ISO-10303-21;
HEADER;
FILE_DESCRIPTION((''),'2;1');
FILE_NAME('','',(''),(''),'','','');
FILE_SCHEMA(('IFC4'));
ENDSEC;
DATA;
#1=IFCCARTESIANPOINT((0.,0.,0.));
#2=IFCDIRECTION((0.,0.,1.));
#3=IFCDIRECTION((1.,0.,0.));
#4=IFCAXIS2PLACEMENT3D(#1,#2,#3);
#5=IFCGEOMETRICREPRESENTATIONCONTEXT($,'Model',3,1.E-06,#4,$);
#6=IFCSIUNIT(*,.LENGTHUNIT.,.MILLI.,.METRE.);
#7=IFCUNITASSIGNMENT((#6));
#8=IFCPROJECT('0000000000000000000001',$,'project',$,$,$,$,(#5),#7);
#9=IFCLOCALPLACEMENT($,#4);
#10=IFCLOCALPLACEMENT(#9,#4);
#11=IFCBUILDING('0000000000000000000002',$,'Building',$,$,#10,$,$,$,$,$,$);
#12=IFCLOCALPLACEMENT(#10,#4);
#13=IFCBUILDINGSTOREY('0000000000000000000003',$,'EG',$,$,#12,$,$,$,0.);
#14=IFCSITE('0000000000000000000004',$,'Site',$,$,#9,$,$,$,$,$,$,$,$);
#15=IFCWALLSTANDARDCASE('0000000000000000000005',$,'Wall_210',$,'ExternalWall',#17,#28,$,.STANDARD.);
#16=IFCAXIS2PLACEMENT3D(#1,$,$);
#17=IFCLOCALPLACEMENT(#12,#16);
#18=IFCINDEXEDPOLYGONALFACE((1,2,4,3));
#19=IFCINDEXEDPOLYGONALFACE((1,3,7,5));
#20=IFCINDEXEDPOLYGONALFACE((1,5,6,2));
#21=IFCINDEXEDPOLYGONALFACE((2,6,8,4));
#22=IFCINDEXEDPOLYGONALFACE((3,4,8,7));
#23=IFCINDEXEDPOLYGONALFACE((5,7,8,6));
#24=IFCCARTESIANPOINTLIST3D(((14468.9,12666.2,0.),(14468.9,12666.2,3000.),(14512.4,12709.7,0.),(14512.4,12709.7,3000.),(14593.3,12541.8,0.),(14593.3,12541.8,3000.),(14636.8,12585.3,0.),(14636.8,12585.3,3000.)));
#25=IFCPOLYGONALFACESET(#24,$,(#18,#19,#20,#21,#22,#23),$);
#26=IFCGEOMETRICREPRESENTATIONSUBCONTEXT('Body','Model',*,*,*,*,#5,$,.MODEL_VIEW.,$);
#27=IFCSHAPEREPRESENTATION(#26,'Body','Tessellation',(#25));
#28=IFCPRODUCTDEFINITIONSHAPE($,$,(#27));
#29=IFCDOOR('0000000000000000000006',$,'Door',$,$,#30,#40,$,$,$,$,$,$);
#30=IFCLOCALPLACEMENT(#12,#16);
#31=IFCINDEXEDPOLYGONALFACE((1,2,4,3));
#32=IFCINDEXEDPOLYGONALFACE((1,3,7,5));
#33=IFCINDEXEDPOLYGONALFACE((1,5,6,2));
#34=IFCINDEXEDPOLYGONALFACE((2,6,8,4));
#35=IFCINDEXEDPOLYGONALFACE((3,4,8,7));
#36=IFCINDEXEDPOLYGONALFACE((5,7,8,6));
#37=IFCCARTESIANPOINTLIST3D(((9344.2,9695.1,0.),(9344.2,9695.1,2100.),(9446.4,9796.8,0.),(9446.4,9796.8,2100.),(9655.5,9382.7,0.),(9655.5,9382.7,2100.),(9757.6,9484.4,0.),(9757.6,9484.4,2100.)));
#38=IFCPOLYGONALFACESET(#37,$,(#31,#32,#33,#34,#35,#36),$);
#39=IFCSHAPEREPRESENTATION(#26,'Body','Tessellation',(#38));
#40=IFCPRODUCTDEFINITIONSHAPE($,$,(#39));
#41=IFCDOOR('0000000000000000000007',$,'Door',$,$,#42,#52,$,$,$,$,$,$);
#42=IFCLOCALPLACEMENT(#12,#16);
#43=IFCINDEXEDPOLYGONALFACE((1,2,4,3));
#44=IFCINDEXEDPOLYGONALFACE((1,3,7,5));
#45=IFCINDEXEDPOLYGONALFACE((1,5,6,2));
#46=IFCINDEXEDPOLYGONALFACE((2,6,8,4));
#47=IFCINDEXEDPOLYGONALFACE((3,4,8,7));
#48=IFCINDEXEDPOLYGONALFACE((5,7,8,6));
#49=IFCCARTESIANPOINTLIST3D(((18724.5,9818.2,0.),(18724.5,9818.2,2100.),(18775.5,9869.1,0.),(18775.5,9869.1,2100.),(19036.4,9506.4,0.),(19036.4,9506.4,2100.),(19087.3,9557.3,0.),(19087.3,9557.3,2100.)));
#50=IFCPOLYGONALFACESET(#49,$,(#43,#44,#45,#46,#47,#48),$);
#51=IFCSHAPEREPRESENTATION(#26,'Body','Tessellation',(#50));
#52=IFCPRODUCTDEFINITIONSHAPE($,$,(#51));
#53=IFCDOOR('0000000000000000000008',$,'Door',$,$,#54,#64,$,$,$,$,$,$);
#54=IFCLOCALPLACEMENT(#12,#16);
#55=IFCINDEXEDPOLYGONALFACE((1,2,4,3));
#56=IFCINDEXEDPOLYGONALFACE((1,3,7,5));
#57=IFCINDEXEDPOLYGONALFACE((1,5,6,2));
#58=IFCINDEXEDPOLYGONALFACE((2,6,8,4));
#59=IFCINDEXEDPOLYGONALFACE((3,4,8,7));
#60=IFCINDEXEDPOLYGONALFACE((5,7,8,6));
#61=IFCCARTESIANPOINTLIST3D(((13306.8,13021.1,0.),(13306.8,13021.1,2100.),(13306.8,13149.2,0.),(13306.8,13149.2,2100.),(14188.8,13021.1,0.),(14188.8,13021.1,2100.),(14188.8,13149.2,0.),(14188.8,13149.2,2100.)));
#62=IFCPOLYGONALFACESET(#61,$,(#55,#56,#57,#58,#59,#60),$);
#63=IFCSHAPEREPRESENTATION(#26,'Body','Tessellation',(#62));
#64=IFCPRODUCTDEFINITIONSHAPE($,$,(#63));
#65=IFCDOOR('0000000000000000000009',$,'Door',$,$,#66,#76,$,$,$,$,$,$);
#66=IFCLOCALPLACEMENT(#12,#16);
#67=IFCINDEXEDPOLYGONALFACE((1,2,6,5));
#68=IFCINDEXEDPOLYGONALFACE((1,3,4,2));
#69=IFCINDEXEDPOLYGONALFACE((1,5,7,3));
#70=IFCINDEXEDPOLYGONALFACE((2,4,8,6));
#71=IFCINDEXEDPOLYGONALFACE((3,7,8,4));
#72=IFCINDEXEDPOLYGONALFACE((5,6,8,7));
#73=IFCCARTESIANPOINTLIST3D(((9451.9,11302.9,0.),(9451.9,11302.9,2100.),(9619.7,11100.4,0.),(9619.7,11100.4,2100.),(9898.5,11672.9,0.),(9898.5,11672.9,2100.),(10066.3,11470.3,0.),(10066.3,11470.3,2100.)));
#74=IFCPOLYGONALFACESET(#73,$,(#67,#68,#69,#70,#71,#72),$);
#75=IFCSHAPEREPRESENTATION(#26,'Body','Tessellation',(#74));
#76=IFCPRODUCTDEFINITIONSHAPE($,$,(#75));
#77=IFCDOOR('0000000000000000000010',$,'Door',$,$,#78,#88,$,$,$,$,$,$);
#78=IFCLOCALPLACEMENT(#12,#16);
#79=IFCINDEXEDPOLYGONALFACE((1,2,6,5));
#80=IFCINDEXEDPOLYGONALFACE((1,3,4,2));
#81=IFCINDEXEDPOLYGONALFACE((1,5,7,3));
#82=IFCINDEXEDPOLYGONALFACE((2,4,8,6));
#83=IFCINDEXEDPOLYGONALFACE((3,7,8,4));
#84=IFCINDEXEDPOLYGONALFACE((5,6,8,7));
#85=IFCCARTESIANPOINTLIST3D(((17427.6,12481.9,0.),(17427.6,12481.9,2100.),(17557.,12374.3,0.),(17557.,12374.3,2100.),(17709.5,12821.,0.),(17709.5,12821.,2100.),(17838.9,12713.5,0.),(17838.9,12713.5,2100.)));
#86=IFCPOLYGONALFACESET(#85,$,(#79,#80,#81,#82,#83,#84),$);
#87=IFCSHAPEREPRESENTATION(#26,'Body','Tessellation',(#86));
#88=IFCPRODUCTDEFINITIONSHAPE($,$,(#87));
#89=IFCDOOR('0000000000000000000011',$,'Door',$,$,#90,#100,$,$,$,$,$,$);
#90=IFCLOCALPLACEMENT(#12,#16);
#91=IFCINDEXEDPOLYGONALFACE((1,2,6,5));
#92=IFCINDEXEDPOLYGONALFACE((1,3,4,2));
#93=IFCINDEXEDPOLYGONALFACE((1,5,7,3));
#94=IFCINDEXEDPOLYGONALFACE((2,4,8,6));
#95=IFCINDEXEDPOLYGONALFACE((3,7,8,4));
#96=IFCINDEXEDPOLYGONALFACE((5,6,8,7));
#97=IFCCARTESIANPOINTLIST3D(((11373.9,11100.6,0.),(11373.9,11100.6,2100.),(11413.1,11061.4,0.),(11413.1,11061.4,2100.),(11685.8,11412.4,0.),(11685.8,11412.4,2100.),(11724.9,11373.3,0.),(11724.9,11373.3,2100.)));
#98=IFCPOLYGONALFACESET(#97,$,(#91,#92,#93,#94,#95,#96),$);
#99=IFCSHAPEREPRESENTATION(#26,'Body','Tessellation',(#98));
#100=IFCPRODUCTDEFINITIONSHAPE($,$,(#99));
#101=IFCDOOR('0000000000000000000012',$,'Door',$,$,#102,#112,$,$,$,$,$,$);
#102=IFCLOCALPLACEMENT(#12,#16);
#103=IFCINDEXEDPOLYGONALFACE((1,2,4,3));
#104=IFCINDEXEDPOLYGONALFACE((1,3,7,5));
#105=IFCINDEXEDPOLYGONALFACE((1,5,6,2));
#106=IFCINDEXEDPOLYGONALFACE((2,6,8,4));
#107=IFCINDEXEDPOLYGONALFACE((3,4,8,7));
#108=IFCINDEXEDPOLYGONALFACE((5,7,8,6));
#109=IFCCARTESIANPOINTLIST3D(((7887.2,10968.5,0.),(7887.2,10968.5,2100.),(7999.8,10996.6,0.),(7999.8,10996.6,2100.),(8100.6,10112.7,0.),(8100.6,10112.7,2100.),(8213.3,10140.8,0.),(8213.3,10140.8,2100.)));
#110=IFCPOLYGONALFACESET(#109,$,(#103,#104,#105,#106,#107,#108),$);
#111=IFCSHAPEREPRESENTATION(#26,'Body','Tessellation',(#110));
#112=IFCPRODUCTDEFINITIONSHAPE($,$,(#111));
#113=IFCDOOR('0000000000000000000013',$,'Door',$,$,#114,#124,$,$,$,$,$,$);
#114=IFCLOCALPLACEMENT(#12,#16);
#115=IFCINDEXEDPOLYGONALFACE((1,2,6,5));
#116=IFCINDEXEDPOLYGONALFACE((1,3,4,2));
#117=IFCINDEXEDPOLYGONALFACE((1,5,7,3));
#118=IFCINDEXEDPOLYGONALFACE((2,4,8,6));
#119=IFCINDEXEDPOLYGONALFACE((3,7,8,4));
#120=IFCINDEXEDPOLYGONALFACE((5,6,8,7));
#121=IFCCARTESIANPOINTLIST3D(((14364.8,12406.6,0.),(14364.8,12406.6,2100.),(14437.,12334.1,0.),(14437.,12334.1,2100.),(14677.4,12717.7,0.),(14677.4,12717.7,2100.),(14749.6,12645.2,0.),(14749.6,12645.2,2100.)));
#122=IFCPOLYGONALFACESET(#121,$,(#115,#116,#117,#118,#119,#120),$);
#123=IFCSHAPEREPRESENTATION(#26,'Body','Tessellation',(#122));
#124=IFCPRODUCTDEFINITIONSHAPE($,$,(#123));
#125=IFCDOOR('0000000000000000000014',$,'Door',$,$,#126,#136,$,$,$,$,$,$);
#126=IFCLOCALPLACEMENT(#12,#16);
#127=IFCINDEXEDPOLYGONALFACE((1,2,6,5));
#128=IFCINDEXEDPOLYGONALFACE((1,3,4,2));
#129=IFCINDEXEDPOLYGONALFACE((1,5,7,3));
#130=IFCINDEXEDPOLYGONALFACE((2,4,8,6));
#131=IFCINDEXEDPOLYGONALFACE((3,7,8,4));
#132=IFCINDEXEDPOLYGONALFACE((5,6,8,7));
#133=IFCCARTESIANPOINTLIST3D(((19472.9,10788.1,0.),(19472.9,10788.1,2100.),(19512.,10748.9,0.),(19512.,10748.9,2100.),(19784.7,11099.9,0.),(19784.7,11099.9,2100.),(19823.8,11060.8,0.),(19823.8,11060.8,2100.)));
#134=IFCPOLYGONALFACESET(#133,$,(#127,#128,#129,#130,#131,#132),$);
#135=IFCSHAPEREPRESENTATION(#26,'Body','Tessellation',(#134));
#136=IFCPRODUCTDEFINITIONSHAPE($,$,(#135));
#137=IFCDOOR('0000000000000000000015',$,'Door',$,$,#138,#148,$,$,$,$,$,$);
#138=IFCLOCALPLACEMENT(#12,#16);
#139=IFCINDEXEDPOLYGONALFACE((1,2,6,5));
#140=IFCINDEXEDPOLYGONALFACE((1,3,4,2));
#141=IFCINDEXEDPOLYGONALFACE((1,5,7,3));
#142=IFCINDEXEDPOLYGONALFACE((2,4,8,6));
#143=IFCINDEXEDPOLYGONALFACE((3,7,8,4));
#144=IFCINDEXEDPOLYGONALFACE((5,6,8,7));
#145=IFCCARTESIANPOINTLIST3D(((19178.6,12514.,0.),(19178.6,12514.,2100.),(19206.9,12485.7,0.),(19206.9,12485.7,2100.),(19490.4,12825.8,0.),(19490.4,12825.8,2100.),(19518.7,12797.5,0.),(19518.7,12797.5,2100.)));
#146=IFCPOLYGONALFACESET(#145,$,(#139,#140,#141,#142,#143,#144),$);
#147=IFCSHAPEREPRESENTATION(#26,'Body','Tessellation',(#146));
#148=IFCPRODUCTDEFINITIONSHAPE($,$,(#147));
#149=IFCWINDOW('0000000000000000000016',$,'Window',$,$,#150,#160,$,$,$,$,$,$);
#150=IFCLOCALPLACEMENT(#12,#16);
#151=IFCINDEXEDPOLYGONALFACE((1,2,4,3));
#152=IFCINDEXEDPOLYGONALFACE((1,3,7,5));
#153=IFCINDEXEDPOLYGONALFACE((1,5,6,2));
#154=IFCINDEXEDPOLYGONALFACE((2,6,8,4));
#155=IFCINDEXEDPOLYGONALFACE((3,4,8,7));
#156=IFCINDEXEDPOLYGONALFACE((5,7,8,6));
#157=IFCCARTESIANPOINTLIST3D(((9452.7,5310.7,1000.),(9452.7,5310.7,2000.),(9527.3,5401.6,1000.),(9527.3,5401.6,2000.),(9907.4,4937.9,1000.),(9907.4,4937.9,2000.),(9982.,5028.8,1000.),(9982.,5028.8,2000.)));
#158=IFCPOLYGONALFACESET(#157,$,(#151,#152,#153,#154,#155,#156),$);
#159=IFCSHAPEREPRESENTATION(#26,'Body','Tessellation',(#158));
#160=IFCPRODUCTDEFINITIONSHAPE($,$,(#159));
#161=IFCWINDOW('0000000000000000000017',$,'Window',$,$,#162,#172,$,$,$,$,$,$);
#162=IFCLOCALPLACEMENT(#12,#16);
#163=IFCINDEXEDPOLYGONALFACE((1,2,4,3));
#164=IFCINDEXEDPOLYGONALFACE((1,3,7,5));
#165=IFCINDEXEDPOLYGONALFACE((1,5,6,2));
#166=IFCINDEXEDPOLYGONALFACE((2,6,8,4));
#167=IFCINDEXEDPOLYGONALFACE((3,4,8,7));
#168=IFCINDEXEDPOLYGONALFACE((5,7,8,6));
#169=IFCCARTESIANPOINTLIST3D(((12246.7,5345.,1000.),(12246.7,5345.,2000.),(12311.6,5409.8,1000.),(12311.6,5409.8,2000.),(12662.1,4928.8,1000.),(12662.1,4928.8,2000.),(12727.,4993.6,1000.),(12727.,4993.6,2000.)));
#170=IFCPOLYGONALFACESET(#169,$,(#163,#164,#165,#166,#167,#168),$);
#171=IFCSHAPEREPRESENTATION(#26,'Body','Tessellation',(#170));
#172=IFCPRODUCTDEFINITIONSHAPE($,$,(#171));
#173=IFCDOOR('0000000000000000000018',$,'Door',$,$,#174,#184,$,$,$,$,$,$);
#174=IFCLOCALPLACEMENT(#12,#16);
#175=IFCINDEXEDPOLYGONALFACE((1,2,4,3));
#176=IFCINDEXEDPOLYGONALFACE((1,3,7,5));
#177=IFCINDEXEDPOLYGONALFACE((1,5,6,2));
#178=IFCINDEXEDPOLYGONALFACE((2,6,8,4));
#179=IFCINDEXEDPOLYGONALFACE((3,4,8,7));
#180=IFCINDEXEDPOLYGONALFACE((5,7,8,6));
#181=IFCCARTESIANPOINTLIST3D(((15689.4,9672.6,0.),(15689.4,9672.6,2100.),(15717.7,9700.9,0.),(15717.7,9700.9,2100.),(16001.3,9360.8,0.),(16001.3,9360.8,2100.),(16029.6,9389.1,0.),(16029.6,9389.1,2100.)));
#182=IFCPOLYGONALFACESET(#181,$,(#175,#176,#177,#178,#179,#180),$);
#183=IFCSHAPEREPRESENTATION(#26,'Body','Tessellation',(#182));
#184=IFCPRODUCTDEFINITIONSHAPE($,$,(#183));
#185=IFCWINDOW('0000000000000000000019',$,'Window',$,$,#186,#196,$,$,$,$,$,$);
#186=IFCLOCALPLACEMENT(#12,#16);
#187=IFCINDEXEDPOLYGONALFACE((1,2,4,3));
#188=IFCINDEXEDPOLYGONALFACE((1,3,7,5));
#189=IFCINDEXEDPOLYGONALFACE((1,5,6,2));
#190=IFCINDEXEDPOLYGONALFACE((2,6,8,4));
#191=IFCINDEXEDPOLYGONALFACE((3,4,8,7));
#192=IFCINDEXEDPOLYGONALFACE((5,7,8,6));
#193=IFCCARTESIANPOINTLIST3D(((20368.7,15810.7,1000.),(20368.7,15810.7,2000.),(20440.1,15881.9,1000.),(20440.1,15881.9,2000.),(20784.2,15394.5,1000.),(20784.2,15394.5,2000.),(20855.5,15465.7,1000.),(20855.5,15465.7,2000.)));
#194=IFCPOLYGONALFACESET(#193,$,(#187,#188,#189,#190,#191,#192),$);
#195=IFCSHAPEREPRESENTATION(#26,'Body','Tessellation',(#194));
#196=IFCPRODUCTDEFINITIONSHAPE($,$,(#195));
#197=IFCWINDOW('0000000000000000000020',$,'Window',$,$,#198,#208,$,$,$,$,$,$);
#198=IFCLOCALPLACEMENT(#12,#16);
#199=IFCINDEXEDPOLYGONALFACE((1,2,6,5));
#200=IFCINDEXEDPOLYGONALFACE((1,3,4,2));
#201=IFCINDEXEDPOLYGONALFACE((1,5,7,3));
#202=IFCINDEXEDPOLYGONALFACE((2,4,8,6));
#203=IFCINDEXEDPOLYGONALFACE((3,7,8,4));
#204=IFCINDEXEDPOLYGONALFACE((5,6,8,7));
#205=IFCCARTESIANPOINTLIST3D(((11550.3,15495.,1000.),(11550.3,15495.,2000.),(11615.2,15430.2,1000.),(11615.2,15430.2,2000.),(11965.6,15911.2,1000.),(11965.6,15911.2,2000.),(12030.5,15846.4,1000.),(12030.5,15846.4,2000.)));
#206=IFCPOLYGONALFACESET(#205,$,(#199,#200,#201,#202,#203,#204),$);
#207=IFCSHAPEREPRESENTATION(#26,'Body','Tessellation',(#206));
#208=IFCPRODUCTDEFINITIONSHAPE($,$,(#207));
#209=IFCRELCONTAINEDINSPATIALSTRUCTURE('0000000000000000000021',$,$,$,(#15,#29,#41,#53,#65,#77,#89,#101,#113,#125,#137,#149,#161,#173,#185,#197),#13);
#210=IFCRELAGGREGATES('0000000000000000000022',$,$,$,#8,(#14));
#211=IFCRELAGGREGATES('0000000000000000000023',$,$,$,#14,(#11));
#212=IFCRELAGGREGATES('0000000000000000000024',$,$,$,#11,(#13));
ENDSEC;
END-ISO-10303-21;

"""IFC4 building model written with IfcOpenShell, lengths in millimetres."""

from ifc_helpers import new_model, si_unit, frame, origin_with_axes, place, context, subcontext, project, spatial, rectangle, extrude, element, save


model = new_model("IFC4")

# Units and contexts
model_context = context("Model", 3, precision=1e-06, world=origin_with_axes())
body_context = subcontext(model_context, "Body", "Model", "MODEL_VIEW")
ifc_project = project(units=[si_unit("LENGTHUNIT", "METRE", prefix="MILLI")], contexts=[model_context])

# Site, building, storey
site_placement = place(None, origin_with_axes())
site = spatial("IfcSite", under=ifc_project, at=site_placement, Name="Site")
building_placement = place(site_placement, origin_with_axes())
building = spatial("IfcBuilding", under=site, at=building_placement, Name="Building")
storey_placement = place(building_placement, origin_with_axes())
storey = spatial("IfcBuildingStorey", under=building, at=storey_placement, Name="EG", Elevation=0.0)

# Wall
wall_placement = place(storey_placement, origin_with_axes())
element("IfcWallStandardCase", 1, at=wall_placement, inside=storey, Name="Wall_210", ObjectType="ExternalWall", PredefinedType="STANDARD", context=body_context, shape_type="SweptSolid", body=[
    extrude(rectangle(XDim=61.5, YDim=175.9), frame((14552.8, 12625.8, 0.0), z_axis=(0.0, 0.0, 1.0), x_axis=(-0.707107, -0.707107, 0.0)), (0.0, 0.0, 1.0), 3000.0),
])

# Doors
door_1_placement = place(storey_placement, origin_with_axes())
element("IfcDoor", 2, at=door_1_placement, inside=storey, Name="Door", context=body_context, shape_type="SweptSolid", body=[
    extrude(rectangle(XDim=441.0, YDim=144.2), frame((9550.9, 9589.8, 0.0), z_axis=(0.0, 0.0, 1.0), x_axis=(0.705748, -0.708463, 0.0)), (0.0, 0.0, 1.0), 2100.0),
])
door_2_placement = place(storey_placement, origin_with_axes())
element("IfcDoor", 3, at=door_2_placement, inside=storey, Name="Door", context=body_context, shape_type="SweptSolid", body=[
    extrude(rectangle(XDim=441.0, YDim=72.0), frame((18905.9, 9687.8, 0.0), z_axis=(0.0, 0.0, 1.0), x_axis=(0.707107, -0.707107, 0.0)), (0.0, 0.0, 1.0), 2100.0),
])
door_3_placement = place(storey_placement, origin_with_axes())
element("IfcDoor", 4, at=door_3_placement, inside=storey, Name="Door", context=body_context, shape_type="SweptSolid", body=[
    extrude(rectangle(XDim=882.0, YDim=128.1), frame((13747.8, 13085.1, 0.0), z_axis=(0.0, 0.0, 1.0), x_axis=(-1.0, 0.0, 0.0)), (0.0, 0.0, 1.0), 2100.0),
])
door_4_placement = place(storey_placement, origin_with_axes())
element("IfcDoor", 5, at=door_4_placement, inside=storey, Name="Door", context=body_context, shape_type="SweptSolid", body=[
    extrude(rectangle(XDim=580.0, YDim=263.0), frame((9759.1, 11386.6, 0.0), z_axis=(0.0, 0.0, 1.0), x_axis=(-0.770122, -0.637896, 0.0)), (0.0, 0.0, 1.0), 2100.0),
])
door_5_placement = place(storey_placement, origin_with_axes())
element("IfcDoor", 6, at=door_5_placement, inside=storey, Name="Door", context=body_context, shape_type="SweptSolid", body=[
    extrude(rectangle(XDim=441.0, YDim=168.2), frame((17633.3, 12597.7, 0.0), z_axis=(0.0, 0.0, 1.0), x_axis=(-0.639217, -0.769027, 0.0)), (0.0, 0.0, 1.0), 2100.0),
])
door_6_placement = place(storey_placement, origin_with_axes())
element("IfcDoor", 7, at=door_6_placement, inside=storey, Name="Door", context=body_context, shape_type="SweptSolid", body=[
    extrude(rectangle(XDim=441.0, YDim=55.3), frame((11549.4, 11236.9, 0.0), z_axis=(0.0, 0.0, 1.0), x_axis=(-0.707107, -0.707107, 0.0)), (0.0, 0.0, 1.0), 2100.0),
])
door_7_placement = place(storey_placement, origin_with_axes())
element("IfcDoor", 8, at=door_7_placement, inside=storey, Name="Door", context=body_context, shape_type="SweptSolid", body=[
    extrude(rectangle(XDim=882.0, YDim=116.1), frame((8050.2, 10554.7, 0.0), z_axis=(0.0, 0.0, 1.0), x_axis=(-0.241988, 0.970279, 0.0)), (0.0, 0.0, 1.0), 2100.0),
])
door_8_placement = place(storey_placement, origin_with_axes())
element("IfcDoor", 9, at=door_8_placement, inside=storey, Name="Door", context=body_context, shape_type="SweptSolid", body=[
    extrude(rectangle(XDim=441.0, YDim=102.3), frame((14557.2, 12525.9, 0.0), z_axis=(0.0, 0.0, 1.0), x_axis=(-0.7088, -0.705409, 0.0)), (0.0, 0.0, 1.0), 2100.0),
])
door_9_placement = place(storey_placement, origin_with_axes())
element("IfcDoor", 10, at=door_9_placement, inside=storey, Name="Door", context=body_context, shape_type="SweptSolid", body=[
    extrude(rectangle(XDim=441.0, YDim=55.3), frame((19648.4, 10924.4, 0.0), z_axis=(0.0, 0.0, 1.0), x_axis=(-0.707107, -0.707107, 0.0)), (0.0, 0.0, 1.0), 2100.0),
])
door_10_placement = place(storey_placement, origin_with_axes())
element("IfcDoor", 11, at=door_10_placement, inside=storey, Name="Door", context=body_context, shape_type="SweptSolid", body=[
    extrude(rectangle(XDim=441.0, YDim=40.0), frame((19348.7, 12655.8, 0.0), z_axis=(0.0, 0.0, 1.0), x_axis=(-0.707107, -0.707107, 0.0)), (0.0, 0.0, 1.0), 2100.0),
])

# Windows
window_1_placement = place(storey_placement, origin_with_axes())
element("IfcWindow", 12, at=window_1_placement, inside=storey, Name="Window", context=body_context, shape_type="SweptSolid", body=[
    extrude(rectangle(XDim=588.0, YDim=117.6), frame((9717.4, 5169.8, 1000.0), z_axis=(0.0, 0.0, 1.0), x_axis=(0.773294, -0.634047, 0.0)), (0.0, 0.0, 1.0), 1000.0),
])
window_2_placement = place(storey_placement, origin_with_axes())
element("IfcWindow", 13, at=window_2_placement, inside=storey, Name="Window", context=body_context, shape_type="SweptSolid", body=[
    extrude(rectangle(XDim=588.0, YDim=91.7), frame((12486.9, 5169.3, 1000.0), z_axis=(0.0, 0.0, 1.0), x_axis=(0.706427, -0.707786, 0.0)), (0.0, 0.0, 1.0), 1000.0),
])

# Door
door_11_placement = place(storey_placement, origin_with_axes())
element("IfcDoor", 14, at=door_11_placement, inside=storey, Name="Door", context=body_context, shape_type="SweptSolid", body=[
    extrude(rectangle(XDim=441.0, YDim=40.0), frame((15859.5, 9530.8, 0.0), z_axis=(0.0, 0.0, 1.0), x_axis=(0.707107, -0.707107, 0.0)), (0.0, 0.0, 1.0), 2100.0),
])

# Windows
window_3_placement = place(storey_placement, origin_with_axes())
element("IfcWindow", 15, at=window_3_placement, inside=storey, Name="Window", context=body_context, shape_type="SweptSolid", body=[
    extrude(rectangle(XDim=588.0, YDim=100.8), frame((20612.1, 15638.2, 1000.0), z_axis=(0.0, 0.0, 1.0), x_axis=(0.706489, -0.707724, 0.0)), (0.0, 0.0, 1.0), 1000.0),
])
window_4_placement = place(storey_placement, origin_with_axes())
element("IfcWindow", 16, at=window_4_placement, inside=storey, Name="Window", context=body_context, shape_type="SweptSolid", body=[
    extrude(rectangle(XDim=588.0, YDim=91.7), frame((11790.4, 15670.7, 1000.0), z_axis=(0.0, 0.0, 1.0), x_axis=(-0.706427, -0.707786, 0.0)), (0.0, 0.0, 1.0), 1000.0),
])

save(model, "model.ifc")
